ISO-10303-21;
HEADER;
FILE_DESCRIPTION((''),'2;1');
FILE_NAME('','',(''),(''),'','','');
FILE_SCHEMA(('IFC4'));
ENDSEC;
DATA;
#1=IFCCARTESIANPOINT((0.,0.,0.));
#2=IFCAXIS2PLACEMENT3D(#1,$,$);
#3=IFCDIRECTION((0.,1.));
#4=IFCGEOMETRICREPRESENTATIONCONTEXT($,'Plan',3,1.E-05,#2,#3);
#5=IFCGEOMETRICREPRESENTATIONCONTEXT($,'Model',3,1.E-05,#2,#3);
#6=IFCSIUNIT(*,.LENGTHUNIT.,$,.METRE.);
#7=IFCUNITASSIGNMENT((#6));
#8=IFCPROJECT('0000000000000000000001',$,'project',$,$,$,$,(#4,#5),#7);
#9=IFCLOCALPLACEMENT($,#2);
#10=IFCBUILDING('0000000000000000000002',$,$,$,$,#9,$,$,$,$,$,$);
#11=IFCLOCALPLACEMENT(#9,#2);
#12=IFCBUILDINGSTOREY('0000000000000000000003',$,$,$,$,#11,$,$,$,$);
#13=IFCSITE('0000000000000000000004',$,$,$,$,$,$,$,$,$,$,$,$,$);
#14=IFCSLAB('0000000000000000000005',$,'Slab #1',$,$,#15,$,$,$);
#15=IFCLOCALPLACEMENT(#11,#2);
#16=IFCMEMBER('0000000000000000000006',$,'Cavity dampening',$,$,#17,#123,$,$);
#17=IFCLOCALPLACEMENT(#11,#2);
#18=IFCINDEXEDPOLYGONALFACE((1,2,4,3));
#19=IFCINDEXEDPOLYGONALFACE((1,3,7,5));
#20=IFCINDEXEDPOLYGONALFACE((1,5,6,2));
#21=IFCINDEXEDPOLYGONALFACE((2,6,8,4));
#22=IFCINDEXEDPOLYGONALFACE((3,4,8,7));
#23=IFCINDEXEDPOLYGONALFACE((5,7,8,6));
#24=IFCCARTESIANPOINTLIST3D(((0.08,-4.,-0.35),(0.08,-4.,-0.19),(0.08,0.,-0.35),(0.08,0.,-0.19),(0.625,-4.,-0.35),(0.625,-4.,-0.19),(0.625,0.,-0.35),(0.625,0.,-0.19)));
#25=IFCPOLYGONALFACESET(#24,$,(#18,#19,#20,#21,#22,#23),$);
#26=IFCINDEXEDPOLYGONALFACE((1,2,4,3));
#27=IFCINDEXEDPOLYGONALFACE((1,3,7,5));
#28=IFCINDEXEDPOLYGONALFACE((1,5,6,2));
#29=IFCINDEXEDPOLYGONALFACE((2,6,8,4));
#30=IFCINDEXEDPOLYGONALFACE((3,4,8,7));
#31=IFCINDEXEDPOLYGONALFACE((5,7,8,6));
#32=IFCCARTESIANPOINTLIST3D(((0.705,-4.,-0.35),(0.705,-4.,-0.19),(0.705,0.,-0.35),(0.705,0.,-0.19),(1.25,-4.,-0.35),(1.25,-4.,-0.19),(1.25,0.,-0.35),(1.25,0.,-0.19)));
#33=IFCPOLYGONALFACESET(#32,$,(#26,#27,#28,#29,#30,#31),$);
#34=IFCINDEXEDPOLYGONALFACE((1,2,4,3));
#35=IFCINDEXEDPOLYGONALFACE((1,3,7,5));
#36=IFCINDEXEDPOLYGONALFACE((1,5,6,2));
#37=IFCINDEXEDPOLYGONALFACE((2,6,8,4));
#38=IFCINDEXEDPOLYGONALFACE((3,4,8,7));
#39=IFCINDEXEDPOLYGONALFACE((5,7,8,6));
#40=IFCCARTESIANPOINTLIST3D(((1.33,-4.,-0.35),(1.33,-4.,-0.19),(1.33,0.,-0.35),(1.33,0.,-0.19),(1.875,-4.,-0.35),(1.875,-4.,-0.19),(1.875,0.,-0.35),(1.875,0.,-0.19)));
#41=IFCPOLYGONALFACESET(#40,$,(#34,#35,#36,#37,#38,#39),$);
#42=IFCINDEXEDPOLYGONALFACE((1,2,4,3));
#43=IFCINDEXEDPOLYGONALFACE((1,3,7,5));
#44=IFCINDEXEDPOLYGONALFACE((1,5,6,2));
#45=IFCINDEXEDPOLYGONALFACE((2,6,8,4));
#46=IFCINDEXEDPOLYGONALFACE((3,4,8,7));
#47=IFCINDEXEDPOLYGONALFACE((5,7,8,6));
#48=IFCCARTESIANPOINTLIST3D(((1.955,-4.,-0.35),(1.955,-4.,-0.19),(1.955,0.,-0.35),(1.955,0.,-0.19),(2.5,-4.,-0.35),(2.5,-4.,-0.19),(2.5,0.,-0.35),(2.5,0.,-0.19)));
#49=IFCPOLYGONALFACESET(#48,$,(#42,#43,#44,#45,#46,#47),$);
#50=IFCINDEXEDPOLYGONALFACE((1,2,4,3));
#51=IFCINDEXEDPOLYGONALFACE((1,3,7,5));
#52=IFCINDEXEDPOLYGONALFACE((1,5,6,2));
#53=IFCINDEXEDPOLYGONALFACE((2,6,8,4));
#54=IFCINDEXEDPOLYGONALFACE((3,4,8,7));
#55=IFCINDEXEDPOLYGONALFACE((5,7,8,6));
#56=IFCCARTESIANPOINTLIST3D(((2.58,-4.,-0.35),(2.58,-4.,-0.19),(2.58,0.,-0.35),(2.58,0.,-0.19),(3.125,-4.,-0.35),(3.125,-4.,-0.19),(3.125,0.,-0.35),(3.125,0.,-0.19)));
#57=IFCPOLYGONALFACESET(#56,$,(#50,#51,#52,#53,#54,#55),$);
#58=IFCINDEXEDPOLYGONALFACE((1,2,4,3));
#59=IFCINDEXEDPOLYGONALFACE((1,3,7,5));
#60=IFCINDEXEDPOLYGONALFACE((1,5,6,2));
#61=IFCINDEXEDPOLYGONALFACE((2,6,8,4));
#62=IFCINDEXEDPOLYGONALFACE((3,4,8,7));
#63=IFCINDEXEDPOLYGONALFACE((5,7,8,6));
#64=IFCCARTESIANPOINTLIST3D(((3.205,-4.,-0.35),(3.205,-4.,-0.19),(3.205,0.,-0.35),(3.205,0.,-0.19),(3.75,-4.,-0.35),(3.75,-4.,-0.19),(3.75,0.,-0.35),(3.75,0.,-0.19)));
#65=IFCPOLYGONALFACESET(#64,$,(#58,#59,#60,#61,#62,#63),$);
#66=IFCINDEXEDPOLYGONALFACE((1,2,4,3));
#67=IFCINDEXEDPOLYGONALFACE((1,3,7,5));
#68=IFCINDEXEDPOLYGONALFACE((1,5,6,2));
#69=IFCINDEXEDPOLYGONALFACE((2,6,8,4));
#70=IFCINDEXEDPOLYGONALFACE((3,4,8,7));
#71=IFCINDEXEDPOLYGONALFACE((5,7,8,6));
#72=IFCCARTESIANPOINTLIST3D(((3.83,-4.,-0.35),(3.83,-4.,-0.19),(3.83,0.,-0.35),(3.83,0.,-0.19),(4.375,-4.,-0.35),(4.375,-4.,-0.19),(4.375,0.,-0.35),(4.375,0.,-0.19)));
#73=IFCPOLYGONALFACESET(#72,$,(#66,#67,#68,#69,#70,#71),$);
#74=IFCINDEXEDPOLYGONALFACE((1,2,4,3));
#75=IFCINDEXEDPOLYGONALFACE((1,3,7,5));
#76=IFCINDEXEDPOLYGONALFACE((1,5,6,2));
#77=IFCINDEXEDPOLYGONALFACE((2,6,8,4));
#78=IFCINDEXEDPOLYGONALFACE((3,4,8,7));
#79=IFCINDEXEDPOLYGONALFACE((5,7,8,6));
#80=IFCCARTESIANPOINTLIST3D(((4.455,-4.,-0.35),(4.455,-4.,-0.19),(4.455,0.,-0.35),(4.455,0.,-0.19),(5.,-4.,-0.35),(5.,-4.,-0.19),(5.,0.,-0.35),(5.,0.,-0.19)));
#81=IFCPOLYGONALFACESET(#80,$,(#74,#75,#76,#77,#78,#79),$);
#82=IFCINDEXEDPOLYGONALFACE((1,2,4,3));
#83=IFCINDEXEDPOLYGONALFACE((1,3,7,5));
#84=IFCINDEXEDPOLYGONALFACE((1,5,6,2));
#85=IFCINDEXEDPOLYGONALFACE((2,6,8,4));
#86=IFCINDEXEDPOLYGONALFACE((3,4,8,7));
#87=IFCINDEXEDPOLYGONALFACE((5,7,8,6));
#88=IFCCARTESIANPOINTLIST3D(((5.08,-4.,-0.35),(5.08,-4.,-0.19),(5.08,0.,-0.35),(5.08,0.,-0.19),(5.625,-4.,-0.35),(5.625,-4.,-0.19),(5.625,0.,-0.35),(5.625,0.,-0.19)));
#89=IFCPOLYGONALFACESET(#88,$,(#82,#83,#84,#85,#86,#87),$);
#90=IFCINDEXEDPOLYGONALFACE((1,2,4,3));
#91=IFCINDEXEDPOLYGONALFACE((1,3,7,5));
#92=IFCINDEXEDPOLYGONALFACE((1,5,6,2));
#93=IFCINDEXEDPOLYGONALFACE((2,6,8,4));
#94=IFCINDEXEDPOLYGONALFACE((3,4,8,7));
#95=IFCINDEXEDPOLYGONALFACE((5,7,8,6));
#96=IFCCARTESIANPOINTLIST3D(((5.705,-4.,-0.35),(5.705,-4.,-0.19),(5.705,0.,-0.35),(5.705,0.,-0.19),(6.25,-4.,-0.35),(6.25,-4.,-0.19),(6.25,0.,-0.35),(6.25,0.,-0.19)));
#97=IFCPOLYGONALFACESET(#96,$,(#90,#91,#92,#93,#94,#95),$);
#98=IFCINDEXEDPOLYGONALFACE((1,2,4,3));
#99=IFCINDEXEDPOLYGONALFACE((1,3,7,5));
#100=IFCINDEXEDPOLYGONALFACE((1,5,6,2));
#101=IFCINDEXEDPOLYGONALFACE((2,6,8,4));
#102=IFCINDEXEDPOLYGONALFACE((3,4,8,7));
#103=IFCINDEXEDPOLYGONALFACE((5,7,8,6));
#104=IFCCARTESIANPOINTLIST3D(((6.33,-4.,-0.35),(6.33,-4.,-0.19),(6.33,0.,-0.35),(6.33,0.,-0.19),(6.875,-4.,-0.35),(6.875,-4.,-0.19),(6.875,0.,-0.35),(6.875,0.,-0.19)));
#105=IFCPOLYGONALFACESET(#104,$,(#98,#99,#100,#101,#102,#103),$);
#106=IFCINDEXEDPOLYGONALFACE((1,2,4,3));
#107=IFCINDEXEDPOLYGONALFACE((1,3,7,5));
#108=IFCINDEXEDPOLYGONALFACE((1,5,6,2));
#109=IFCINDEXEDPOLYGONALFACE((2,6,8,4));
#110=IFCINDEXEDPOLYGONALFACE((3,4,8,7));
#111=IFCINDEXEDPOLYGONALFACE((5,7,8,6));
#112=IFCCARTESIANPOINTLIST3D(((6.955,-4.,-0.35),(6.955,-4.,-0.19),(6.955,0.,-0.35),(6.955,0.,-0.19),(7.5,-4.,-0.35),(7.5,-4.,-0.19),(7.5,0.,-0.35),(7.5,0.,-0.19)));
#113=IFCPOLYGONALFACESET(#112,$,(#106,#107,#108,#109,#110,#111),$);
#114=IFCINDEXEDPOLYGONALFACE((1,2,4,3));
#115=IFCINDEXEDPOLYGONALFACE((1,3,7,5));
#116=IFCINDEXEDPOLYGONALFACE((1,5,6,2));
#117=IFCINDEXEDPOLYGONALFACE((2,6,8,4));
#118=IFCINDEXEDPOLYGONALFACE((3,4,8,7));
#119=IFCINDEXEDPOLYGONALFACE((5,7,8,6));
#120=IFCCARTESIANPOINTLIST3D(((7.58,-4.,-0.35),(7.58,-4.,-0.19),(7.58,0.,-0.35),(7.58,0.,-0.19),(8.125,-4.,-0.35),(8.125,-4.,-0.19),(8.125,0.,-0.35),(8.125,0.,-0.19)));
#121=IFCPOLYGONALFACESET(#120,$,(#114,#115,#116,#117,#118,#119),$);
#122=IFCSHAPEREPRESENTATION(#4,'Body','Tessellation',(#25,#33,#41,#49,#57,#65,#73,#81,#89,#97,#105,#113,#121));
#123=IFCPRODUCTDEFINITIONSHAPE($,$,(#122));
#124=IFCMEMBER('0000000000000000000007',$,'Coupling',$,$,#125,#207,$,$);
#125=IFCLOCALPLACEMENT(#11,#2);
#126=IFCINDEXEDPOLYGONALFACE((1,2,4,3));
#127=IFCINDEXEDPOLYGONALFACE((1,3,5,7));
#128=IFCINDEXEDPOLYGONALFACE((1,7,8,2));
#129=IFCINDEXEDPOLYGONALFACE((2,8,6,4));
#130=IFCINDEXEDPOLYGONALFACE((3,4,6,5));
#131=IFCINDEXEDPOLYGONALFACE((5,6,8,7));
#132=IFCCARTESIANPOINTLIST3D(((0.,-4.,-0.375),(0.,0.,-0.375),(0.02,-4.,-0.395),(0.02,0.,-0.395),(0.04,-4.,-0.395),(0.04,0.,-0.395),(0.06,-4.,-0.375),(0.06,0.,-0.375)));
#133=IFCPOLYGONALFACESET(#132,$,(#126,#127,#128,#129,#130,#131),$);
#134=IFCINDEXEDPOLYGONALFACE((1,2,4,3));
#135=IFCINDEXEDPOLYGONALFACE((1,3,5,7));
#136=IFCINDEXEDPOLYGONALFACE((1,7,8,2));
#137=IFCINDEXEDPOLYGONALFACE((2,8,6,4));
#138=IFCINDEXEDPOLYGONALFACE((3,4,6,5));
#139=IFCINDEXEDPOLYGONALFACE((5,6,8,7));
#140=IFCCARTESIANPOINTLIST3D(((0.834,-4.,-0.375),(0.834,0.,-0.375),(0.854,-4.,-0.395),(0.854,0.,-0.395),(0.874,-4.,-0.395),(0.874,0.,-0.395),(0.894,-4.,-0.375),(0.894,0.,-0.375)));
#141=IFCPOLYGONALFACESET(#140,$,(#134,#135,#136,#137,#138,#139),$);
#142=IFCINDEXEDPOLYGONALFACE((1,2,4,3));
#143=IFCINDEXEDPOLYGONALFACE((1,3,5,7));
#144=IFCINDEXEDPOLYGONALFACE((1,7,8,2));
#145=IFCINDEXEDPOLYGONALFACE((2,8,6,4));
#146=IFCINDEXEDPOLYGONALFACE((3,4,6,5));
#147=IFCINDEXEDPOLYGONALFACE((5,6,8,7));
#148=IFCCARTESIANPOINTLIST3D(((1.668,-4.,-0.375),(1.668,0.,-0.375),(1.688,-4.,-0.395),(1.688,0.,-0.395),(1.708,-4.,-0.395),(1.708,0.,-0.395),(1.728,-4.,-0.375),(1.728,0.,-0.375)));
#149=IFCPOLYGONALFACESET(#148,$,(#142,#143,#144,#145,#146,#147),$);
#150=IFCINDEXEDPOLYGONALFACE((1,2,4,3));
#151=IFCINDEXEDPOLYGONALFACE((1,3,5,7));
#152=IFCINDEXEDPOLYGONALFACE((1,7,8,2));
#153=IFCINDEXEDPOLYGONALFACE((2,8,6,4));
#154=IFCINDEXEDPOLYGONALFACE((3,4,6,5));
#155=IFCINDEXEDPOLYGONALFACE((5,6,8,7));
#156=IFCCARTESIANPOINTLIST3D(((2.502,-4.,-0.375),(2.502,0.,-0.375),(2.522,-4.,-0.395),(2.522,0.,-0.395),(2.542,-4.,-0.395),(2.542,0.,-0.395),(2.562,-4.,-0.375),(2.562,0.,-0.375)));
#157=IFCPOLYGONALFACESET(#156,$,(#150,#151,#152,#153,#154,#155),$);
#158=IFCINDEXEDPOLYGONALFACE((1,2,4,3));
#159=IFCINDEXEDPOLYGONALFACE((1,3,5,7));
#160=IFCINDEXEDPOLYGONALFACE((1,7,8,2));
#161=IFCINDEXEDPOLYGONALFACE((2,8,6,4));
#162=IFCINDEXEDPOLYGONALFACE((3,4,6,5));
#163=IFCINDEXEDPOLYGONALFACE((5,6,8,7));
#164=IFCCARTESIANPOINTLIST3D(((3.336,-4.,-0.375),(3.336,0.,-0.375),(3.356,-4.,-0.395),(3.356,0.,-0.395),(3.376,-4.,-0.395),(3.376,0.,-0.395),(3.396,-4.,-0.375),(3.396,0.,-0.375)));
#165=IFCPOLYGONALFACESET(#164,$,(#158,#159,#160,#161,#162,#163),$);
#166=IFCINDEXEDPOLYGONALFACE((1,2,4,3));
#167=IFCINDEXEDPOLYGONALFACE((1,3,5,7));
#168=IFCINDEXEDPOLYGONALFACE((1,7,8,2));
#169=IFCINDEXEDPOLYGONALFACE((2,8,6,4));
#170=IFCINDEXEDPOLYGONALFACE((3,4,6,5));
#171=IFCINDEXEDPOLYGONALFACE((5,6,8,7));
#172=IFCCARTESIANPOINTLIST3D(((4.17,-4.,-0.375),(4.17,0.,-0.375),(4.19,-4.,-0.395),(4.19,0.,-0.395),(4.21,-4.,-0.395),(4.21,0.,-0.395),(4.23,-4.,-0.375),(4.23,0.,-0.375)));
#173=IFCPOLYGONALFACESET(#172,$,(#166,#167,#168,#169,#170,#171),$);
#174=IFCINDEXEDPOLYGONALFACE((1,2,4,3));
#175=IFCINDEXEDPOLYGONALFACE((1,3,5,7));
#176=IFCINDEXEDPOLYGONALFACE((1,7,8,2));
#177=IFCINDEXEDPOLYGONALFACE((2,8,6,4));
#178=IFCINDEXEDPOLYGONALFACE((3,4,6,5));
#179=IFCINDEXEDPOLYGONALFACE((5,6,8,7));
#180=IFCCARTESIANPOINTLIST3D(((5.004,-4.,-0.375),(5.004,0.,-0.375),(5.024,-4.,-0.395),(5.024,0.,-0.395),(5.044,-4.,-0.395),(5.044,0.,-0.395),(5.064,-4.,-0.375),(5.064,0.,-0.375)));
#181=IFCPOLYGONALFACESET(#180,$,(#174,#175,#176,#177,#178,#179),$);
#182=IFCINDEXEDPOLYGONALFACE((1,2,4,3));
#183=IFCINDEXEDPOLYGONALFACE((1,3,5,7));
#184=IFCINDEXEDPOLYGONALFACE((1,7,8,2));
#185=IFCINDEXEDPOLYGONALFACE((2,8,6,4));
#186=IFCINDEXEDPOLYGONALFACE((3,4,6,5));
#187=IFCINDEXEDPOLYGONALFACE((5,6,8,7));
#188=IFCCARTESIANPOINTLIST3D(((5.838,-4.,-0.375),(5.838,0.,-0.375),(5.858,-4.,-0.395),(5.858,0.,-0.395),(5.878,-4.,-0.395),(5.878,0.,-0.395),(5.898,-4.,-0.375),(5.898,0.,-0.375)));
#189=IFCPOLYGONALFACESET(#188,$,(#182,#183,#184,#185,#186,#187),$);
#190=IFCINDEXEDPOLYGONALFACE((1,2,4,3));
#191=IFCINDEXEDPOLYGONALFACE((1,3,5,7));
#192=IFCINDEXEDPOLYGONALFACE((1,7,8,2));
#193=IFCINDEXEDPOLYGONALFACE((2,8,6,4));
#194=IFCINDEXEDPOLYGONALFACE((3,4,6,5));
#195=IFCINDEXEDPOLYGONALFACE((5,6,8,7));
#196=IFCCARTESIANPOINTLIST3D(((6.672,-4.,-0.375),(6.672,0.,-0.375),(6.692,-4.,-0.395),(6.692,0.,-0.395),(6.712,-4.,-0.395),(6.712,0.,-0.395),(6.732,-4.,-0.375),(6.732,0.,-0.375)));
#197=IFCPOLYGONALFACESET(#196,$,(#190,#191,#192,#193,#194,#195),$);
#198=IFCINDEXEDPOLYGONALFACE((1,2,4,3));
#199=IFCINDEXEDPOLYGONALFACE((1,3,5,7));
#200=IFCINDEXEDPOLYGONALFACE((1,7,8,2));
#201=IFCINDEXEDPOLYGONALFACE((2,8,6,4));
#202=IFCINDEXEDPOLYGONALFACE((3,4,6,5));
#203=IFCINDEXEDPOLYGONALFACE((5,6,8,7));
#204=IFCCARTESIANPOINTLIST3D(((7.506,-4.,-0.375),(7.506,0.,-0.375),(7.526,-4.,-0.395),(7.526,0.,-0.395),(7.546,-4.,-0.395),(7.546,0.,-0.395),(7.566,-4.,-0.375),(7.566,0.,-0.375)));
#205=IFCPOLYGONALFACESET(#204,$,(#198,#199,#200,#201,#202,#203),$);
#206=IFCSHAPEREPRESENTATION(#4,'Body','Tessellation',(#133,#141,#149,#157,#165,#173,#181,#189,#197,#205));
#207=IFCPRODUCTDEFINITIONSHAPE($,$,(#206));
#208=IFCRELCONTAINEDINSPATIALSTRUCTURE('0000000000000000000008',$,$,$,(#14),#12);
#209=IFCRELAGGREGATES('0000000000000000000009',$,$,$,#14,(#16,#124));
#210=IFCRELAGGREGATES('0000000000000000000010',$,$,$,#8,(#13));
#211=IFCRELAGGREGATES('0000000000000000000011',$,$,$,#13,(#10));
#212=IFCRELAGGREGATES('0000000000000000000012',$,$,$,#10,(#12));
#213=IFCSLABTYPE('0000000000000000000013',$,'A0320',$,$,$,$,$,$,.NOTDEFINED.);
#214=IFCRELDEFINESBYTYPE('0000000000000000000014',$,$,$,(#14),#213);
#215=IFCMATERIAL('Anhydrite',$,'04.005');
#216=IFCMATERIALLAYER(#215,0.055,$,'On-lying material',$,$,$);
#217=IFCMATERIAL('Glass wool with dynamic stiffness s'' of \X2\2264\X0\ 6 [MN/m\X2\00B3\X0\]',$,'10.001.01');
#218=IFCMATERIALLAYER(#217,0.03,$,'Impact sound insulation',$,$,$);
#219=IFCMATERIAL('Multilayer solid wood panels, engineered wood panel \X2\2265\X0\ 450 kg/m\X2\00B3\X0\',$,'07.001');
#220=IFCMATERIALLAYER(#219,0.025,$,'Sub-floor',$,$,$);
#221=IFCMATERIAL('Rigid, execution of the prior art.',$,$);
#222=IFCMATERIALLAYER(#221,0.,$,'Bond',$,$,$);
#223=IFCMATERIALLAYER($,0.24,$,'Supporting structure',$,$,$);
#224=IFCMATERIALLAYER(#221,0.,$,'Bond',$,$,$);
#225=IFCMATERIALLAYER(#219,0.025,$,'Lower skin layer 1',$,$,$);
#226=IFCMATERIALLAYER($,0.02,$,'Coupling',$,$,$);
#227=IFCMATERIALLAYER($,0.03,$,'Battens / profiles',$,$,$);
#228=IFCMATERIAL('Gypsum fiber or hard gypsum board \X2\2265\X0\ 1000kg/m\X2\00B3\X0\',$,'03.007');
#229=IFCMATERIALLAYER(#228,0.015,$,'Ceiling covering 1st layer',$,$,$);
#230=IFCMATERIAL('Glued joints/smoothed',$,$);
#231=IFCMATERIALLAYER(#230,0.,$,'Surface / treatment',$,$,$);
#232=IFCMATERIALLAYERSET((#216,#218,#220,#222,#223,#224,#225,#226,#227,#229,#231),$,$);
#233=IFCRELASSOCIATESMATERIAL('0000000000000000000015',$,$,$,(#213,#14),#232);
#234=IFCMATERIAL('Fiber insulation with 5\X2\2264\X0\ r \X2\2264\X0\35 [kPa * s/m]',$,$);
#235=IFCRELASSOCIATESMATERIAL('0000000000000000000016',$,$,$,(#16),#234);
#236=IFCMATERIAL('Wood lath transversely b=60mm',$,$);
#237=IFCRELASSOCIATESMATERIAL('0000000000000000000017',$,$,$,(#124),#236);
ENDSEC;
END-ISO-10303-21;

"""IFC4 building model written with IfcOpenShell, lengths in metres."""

from ifc_helpers import new_model, si_unit, direction, frame, frame_2d, origin, place, context, project, spatial, polyline, rectangle, outline, extrude, material, layer, layer_set, type_object, element, aggregate, save


model = new_model("IFC4")

# Units and contexts
plan_context = context("Plan", 3, precision=1e-05, world=origin(), true_north=direction((0.0, 1.0)))
model_context = context("Model", 3, precision=1e-05, world=origin(), true_north=direction((0.0, 1.0)))
ifc_project = project(units=[si_unit("LENGTHUNIT", "METRE")], contexts=[plan_context, model_context])

# Site, building, storey
site = spatial("IfcSite", under=ifc_project)
building_placement = place(None, origin())
building = spatial("IfcBuilding", under=site, at=building_placement)
storey_placement = place(building_placement, origin())
storey = spatial("IfcBuildingStorey", under=building, at=storey_placement)

# Slab, members
ifc_material_1 = material(Name="Anhydrite", Category="04.005")
ifc_layer_1 = layer(ifc_material_1, 0.055, Name="On-lying material")
ifc_material_2 = material(Name="Glass wool with dynamic stiffness s' of ≤ 6 [MN/m³]", Category="10.001.01")
ifc_layer_2 = layer(ifc_material_2, 0.03, Name="Impact sound insulation")
ifc_material_3 = material(Name="Multilayer solid wood panels, engineered wood panel ≥ 450 kg/m³", Category="07.001")
ifc_layer_3 = layer(ifc_material_3, 0.025, Name="Sub-floor")
ifc_material_4 = material(Name="Rigid, execution of the prior art.")
ifc_layer_4 = layer(ifc_material_4, 0.0, Name="Bond")
ifc_layer_5 = layer(None, 0.24, Name="Supporting structure")
ifc_layer_6 = layer(ifc_material_4, 0.0, Name="Bond")
ifc_layer_7 = layer(ifc_material_3, 0.025, Name="Lower skin layer 1")
ifc_layer_8 = layer(None, 0.02, Name="Coupling")
ifc_layer_9 = layer(None, 0.03, Name="Battens / profiles")
ifc_material_5 = material(Name="Gypsum fiber or hard gypsum board ≥ 1000kg/m³", Category="03.007")
ifc_layer_10 = layer(ifc_material_5, 0.015, Name="Ceiling covering 1st layer")
ifc_material_6 = material(Name="Glued joints/smoothed")
ifc_layer_11 = layer(ifc_material_6, 0.0, Name="Surface / treatment")
ifc_layer_set = layer_set([ifc_layer_1, ifc_layer_2, ifc_layer_3, ifc_layer_4, ifc_layer_5, ifc_layer_6, ifc_layer_7, ifc_layer_8, ifc_layer_9, ifc_layer_10, ifc_layer_11])
slab_type = type_object("IfcSlabType", Name="A0320", PredefinedType="NOTDEFINED", material=ifc_layer_set)
slab_placement = place(None, frame((0.0, 0.0, 0.0), z_axis=(0.0, 0.0, -1.0), x_axis=(1.0, 0.0, 0.0)))
slab = element("IfcSlab", 1, at=slab_placement, inside=storey, type_object=slab_type, material=ifc_layer_set, Name="Slab #1")
ifc_material_7 = material(Name="Fiber insulation with 5≤ r ≤35 [kPa * s/m]")
member_1_placement = place(slab_placement, origin())
member_1 = element("IfcMember", 2, at=member_1_placement, material=ifc_material_7, Name="Cavity dampening", context=plan_context, shape_type="SweptSolid", body=[
    extrude(rectangle(XDim=0.545, YDim=0.16, at=frame_2d((0.2725, 0.08), x_axis=(1.0, 0.0))), frame((0.08, 4.0, 0.19), z_axis=(0.0, -1.0, 0.0), x_axis=(1.0, 0.0, 0.0)), (0.0, 0.0, 1.0), 4.0),
    extrude(rectangle(XDim=0.545, YDim=0.16, at=frame_2d((0.2725, 0.08), x_axis=(1.0, 0.0))), frame((0.705, 4.0, 0.19), z_axis=(0.0, -1.0, 0.0), x_axis=(1.0, 0.0, 0.0)), (0.0, 0.0, 1.0), 4.0),
    extrude(rectangle(XDim=0.545, YDim=0.16, at=frame_2d((0.2725, 0.08), x_axis=(1.0, 0.0))), frame((1.33, 4.0, 0.19), z_axis=(0.0, -1.0, 0.0), x_axis=(1.0, 0.0, 0.0)), (0.0, 0.0, 1.0), 4.0),
    extrude(rectangle(XDim=0.545, YDim=0.16, at=frame_2d((0.2725, 0.08), x_axis=(1.0, 0.0))), frame((1.955, 4.0, 0.19), z_axis=(0.0, -1.0, 0.0), x_axis=(1.0, 0.0, 0.0)), (0.0, 0.0, 1.0), 4.0),
    extrude(rectangle(XDim=0.545, YDim=0.16, at=frame_2d((0.2725, 0.08), x_axis=(1.0, 0.0))), frame((2.58, 4.0, 0.19), z_axis=(0.0, -1.0, 0.0), x_axis=(1.0, 0.0, 0.0)), (0.0, 0.0, 1.0), 4.0),
    extrude(rectangle(XDim=0.545, YDim=0.16, at=frame_2d((0.2725, 0.08), x_axis=(1.0, 0.0))), frame((3.205, 4.0, 0.19), z_axis=(0.0, -1.0, 0.0), x_axis=(1.0, 0.0, 0.0)), (0.0, 0.0, 1.0), 4.0),
    extrude(rectangle(XDim=0.545, YDim=0.16, at=frame_2d((0.2725, 0.08), x_axis=(1.0, 0.0))), frame((3.83, 4.0, 0.19), z_axis=(0.0, -1.0, 0.0), x_axis=(1.0, 0.0, 0.0)), (0.0, 0.0, 1.0), 4.0),
    extrude(rectangle(XDim=0.545, YDim=0.16, at=frame_2d((0.2725, 0.08), x_axis=(1.0, 0.0))), frame((4.455, 4.0, 0.19), z_axis=(0.0, -1.0, 0.0), x_axis=(1.0, 0.0, 0.0)), (0.0, 0.0, 1.0), 4.0),
    extrude(rectangle(XDim=0.545, YDim=0.16, at=frame_2d((0.2725, 0.08), x_axis=(1.0, 0.0))), frame((5.08, 4.0, 0.19), z_axis=(0.0, -1.0, 0.0), x_axis=(1.0, 0.0, 0.0)), (0.0, 0.0, 1.0), 4.0),
    extrude(rectangle(XDim=0.545, YDim=0.16, at=frame_2d((0.2725, 0.08), x_axis=(1.0, 0.0))), frame((5.705, 4.0, 0.19), z_axis=(0.0, -1.0, 0.0), x_axis=(1.0, 0.0, 0.0)), (0.0, 0.0, 1.0), 4.0),
    extrude(rectangle(XDim=0.545, YDim=0.16, at=frame_2d((0.2725, 0.08), x_axis=(1.0, 0.0))), frame((6.33, 4.0, 0.19), z_axis=(0.0, -1.0, 0.0), x_axis=(1.0, 0.0, 0.0)), (0.0, 0.0, 1.0), 4.0),
    extrude(rectangle(XDim=0.545, YDim=0.16, at=frame_2d((0.2725, 0.08), x_axis=(1.0, 0.0))), frame((6.955, 4.0, 0.19), z_axis=(0.0, -1.0, 0.0), x_axis=(1.0, 0.0, 0.0)), (0.0, 0.0, 1.0), 4.0),
    extrude(rectangle(XDim=0.545, YDim=0.16, at=frame_2d((0.2725, 0.08), x_axis=(1.0, 0.0))), frame((7.58, 4.0, 0.19), z_axis=(0.0, -1.0, 0.0), x_axis=(1.0, 0.0, 0.0)), (0.0, 0.0, 1.0), 4.0),
])
ifc_material_8 = material(Name="Wood lath transversely b=60mm")
member_2_placement = place(slab_placement, origin())
member_2 = element("IfcMember", 3, at=member_2_placement, material=ifc_material_8, Name="Coupling", context=plan_context, shape_type="SweptSolid", body=[
    extrude(outline(polyline([(0.0, 0.0), (0.06, 0.0), (0.04, 0.02), (0.02, 0.02), (0.0, 0.0)])), frame((0.0, 4.0, 0.375), z_axis=(0.0, -1.0, 0.0), x_axis=(1.0, 0.0, 0.0)), (0.0, 0.0, 1.0), 4.0),
    extrude(outline(polyline([(0.0, 0.0), (0.06, 0.0), (0.04, 0.02), (0.02, 0.02), (0.0, 0.0)])), frame((0.834, 4.0, 0.375), z_axis=(0.0, -1.0, 0.0), x_axis=(1.0, 0.0, 0.0)), (0.0, 0.0, 1.0), 4.0),
    extrude(outline(polyline([(0.0, 0.0), (0.06, 0.0), (0.04, 0.02), (0.02, 0.02), (0.0, 0.0)])), frame((1.668, 4.0, 0.375), z_axis=(0.0, -1.0, 0.0), x_axis=(1.0, 0.0, 0.0)), (0.0, 0.0, 1.0), 4.0),
    extrude(outline(polyline([(0.0, 0.0), (0.06, 0.0), (0.04, 0.02), (0.02, 0.02), (0.0, 0.0)])), frame((2.502, 4.0, 0.375), z_axis=(0.0, -1.0, 0.0), x_axis=(1.0, 0.0, 0.0)), (0.0, 0.0, 1.0), 4.0),
    extrude(outline(polyline([(0.0, 0.0), (0.06, 0.0), (0.04, 0.02), (0.02, 0.02), (0.0, 0.0)])), frame((3.336, 4.0, 0.375), z_axis=(0.0, -1.0, 0.0), x_axis=(1.0, 0.0, 0.0)), (0.0, 0.0, 1.0), 4.0),
    extrude(outline(polyline([(0.0, 0.0), (0.06, 0.0), (0.04, 0.02), (0.02, 0.02), (0.0, 0.0)])), frame((4.17, 4.0, 0.375), z_axis=(0.0, -1.0, 0.0), x_axis=(1.0, 0.0, 0.0)), (0.0, 0.0, 1.0), 4.0),
    extrude(outline(polyline([(0.0, 0.0), (0.06, 0.0), (0.04, 0.02), (0.02, 0.02), (0.0, 0.0)])), frame((5.004, 4.0, 0.375), z_axis=(0.0, -1.0, 0.0), x_axis=(1.0, 0.0, 0.0)), (0.0, 0.0, 1.0), 4.0),
    extrude(outline(polyline([(0.0, 0.0), (0.06, 0.0), (0.04, 0.02), (0.02, 0.02), (0.0, 0.0)])), frame((5.838, 4.0, 0.375), z_axis=(0.0, -1.0, 0.0), x_axis=(1.0, 0.0, 0.0)), (0.0, 0.0, 1.0), 4.0),
    extrude(outline(polyline([(0.0, 0.0), (0.06, 0.0), (0.04, 0.02), (0.02, 0.02), (0.0, 0.0)])), frame((6.672, 4.0, 0.375), z_axis=(0.0, -1.0, 0.0), x_axis=(1.0, 0.0, 0.0)), (0.0, 0.0, 1.0), 4.0),
    extrude(outline(polyline([(0.0, 0.0), (0.06, 0.0), (0.04, 0.02), (0.02, 0.02), (0.0, 0.0)])), frame((7.506, 4.0, 0.375), z_axis=(0.0, -1.0, 0.0), x_axis=(1.0, 0.0, 0.0)), (0.0, 0.0, 1.0), 4.0),
])
aggregate(slab, [member_1, member_2])

save(model, "model.ifc")
